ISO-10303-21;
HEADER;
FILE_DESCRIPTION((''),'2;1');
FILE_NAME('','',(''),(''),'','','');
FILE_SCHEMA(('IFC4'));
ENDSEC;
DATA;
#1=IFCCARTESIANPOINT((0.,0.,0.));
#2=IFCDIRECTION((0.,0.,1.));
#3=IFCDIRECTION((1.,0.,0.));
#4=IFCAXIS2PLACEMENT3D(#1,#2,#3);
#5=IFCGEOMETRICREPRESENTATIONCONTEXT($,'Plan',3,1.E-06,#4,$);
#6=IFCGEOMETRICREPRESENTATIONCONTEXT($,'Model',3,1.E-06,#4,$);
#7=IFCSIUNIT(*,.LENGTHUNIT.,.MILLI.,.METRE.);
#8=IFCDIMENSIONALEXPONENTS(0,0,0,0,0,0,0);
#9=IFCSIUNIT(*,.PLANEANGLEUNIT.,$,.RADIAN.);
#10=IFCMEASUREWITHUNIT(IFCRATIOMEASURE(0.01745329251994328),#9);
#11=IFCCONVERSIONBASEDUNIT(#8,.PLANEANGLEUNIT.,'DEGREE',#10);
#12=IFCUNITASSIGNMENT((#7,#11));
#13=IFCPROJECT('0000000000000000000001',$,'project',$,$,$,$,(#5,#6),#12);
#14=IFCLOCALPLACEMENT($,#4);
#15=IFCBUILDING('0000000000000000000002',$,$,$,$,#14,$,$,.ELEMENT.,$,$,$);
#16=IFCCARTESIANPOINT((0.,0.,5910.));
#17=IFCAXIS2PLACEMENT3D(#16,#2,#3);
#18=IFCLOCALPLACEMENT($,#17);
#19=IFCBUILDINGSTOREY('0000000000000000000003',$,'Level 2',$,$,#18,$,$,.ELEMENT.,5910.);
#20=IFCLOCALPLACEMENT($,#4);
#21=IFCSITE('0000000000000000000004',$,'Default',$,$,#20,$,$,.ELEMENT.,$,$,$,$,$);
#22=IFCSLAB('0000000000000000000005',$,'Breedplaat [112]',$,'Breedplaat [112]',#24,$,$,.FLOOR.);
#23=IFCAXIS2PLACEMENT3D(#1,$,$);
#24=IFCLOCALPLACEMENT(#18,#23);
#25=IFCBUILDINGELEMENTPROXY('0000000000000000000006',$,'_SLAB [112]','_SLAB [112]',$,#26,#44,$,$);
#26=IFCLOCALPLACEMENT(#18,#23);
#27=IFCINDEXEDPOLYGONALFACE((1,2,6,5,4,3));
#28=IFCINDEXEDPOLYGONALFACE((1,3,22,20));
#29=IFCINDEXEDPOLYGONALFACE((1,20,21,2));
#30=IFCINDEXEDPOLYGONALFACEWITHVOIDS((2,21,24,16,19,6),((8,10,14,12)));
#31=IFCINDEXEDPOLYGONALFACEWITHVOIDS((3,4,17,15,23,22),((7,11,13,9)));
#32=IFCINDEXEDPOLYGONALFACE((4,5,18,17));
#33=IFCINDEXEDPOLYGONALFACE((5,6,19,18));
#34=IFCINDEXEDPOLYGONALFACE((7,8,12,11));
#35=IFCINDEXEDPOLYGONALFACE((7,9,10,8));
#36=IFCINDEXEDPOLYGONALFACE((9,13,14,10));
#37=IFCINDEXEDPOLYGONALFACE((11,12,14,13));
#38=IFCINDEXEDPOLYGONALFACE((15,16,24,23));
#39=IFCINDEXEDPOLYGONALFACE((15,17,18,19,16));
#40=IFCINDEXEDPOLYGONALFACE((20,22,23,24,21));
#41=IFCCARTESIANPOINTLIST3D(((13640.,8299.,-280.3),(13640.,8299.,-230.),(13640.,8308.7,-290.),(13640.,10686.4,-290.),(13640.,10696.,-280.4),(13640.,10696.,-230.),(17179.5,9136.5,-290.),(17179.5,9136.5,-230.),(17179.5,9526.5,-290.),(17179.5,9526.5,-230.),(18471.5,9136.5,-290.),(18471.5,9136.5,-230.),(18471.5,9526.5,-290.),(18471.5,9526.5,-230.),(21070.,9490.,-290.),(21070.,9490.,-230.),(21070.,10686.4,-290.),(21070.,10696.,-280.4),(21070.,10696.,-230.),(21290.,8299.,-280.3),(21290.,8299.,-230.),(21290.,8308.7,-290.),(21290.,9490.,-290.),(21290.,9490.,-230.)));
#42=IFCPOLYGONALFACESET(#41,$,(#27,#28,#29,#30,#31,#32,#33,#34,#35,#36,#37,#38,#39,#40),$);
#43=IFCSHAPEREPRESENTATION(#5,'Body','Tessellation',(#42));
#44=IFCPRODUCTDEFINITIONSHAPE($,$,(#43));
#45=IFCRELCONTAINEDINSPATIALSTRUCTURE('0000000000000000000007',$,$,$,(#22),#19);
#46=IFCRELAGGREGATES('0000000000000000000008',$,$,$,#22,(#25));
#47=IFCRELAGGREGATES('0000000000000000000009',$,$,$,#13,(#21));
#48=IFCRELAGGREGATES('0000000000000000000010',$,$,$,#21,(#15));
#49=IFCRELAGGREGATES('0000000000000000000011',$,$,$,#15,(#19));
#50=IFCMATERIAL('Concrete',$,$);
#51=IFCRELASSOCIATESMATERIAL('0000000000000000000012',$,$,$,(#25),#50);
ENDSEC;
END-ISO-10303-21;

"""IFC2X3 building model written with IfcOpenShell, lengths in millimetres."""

from ifc_helpers import new_model, entity, si_unit, converted_unit, frame, origin_with_axes, origin_2d_with_axis, place, context, project, spatial, polyline, rectangle, outline, extrude, material, element, aggregate, save


model = new_model("IFC2X3")

# Units and contexts
plan_context = context("Plan", 3, precision=1e-06, world=origin_with_axes())
model_context = context("Model", 3, precision=1e-06, world=origin_with_axes())
ifc_project = project(units=[si_unit("LENGTHUNIT", "METRE", prefix="MILLI"), converted_unit("PLANEANGLEUNIT", "DEGREE", entity("IfcRatioMeasure", 0.01745329251994328), si_unit("PLANEANGLEUNIT", "RADIAN"), dimensions=[0, 0, 0, 0, 0, 0, 0])], contexts=[plan_context, model_context])

# Site, building, storey
site_placement = place(None, origin_with_axes())
site = spatial("IfcSite", under=ifc_project, at=site_placement, Name="Default", CompositionType="ELEMENT")
building_placement = place(None, origin_with_axes())
building = spatial("IfcBuilding", under=site, at=building_placement, CompositionType="ELEMENT")
storey_placement = place(None, frame((0.0, 0.0, 5910.0), z_axis=(0.0, 0.0, 1.0), x_axis=(1.0, 0.0, 0.0)))
storey = spatial("IfcBuildingStorey", under=building, at=storey_placement, Name="Level 2", CompositionType="ELEMENT", Elevation=5910.0)

# Slab, building element proxy, openings
slab_1_placement = place(None, frame((13640.0, 8299.0, 5620.0), z_axis=(0.0, 0.0, 1.0), x_axis=(1.0, 0.0, 0.0)))
slab_1 = element("IfcSlab", 1, at=slab_1_placement, inside=storey, Name="Breedplaat [112]", ObjectType="Breedplaat [112]", PredefinedType="FLOOR")
ifc_material_1 = material(Name="Concrete")
proxy_1_placement = place(slab_1_placement, origin_with_axes())
proxy_1 = element("IfcBuildingElementProxy", 2, at=proxy_1_placement, material=ifc_material_1, Name="_SLAB [112]", Description="_SLAB [112]", context=plan_context, shape_type="SweptSolid", body=[
    extrude(outline(polyline([(7650.0, 1191.0), (7430.0, 1191.0), (7430.0, 2397.0), (0.0, 2397.0), (0.0, 0.0), (7650.0, 0.0), (7650.0, 1191.0)])), origin_with_axes(), (0.0, 0.0, 1.0), 60.0),
])
opening_1_placement = place(slab_1_placement, frame((3539.5, 837.5, 0.0), z_axis=(0.0, 0.0, 1.0), x_axis=(1.0, 0.0, 0.0)))
element("IfcOpeningElement", 3, at=opening_1_placement, cuts=proxy_1, ObjectType="Opening", context=plan_context, shape_type="SolidModel", body=[
    extrude(rectangle(XDim=1292.0, YDim=390.0, at=origin_2d_with_axis()), frame((646.0, 195.0, 0.0), z_axis=(0.0, 0.0, 1.0), x_axis=(1.0, 0.0, 0.0)), (0.0, 0.0, 1.0), 60.0),
])
opening_2_placement = place(None, frame((13640.0, 8299.0, 5620.0), z_axis=(0.0, 0.0, 1.0), x_axis=(1.0, 0.0, 0.0)))
element("IfcOpeningElement", 4, at=opening_2_placement, cuts=proxy_1, ObjectType="Opening", context=plan_context, shape_type="SweptSolid", body=[
    extrude(outline(polyline([(-0.1, -0.1), (-0.1, 10.0), (10.0, -0.1), (-0.1, -0.1)])), frame((-1.2, -0.1, -0.1), z_axis=(1.0, 0.0, 0.0), x_axis=(0.0, 1.0, 0.0)), (0.0, 0.0, 1.0), 7652.2),
])
opening_3_placement = place(None, frame((13640.0, 8299.0, 5620.0), z_axis=(0.0, 0.0, 1.0), x_axis=(1.0, 0.0, 0.0)))
element("IfcOpeningElement", 5, at=opening_3_placement, cuts=proxy_1, ObjectType="Opening", context=plan_context, shape_type="SweptSolid", body=[
    extrude(outline(polyline([(-0.1, -0.1), (-0.1, 10.0), (10.0, -0.1), (-0.1, -0.1)])), frame((7431.2, 2397.2, -0.1), z_axis=(-1.0, 0.0, 0.0), x_axis=(0.0, -1.0, 0.0)), (0.0, 0.0, 1.0), 7432.2),
])
aggregate(slab_1, [proxy_1])

save(model, "model.ifc")
